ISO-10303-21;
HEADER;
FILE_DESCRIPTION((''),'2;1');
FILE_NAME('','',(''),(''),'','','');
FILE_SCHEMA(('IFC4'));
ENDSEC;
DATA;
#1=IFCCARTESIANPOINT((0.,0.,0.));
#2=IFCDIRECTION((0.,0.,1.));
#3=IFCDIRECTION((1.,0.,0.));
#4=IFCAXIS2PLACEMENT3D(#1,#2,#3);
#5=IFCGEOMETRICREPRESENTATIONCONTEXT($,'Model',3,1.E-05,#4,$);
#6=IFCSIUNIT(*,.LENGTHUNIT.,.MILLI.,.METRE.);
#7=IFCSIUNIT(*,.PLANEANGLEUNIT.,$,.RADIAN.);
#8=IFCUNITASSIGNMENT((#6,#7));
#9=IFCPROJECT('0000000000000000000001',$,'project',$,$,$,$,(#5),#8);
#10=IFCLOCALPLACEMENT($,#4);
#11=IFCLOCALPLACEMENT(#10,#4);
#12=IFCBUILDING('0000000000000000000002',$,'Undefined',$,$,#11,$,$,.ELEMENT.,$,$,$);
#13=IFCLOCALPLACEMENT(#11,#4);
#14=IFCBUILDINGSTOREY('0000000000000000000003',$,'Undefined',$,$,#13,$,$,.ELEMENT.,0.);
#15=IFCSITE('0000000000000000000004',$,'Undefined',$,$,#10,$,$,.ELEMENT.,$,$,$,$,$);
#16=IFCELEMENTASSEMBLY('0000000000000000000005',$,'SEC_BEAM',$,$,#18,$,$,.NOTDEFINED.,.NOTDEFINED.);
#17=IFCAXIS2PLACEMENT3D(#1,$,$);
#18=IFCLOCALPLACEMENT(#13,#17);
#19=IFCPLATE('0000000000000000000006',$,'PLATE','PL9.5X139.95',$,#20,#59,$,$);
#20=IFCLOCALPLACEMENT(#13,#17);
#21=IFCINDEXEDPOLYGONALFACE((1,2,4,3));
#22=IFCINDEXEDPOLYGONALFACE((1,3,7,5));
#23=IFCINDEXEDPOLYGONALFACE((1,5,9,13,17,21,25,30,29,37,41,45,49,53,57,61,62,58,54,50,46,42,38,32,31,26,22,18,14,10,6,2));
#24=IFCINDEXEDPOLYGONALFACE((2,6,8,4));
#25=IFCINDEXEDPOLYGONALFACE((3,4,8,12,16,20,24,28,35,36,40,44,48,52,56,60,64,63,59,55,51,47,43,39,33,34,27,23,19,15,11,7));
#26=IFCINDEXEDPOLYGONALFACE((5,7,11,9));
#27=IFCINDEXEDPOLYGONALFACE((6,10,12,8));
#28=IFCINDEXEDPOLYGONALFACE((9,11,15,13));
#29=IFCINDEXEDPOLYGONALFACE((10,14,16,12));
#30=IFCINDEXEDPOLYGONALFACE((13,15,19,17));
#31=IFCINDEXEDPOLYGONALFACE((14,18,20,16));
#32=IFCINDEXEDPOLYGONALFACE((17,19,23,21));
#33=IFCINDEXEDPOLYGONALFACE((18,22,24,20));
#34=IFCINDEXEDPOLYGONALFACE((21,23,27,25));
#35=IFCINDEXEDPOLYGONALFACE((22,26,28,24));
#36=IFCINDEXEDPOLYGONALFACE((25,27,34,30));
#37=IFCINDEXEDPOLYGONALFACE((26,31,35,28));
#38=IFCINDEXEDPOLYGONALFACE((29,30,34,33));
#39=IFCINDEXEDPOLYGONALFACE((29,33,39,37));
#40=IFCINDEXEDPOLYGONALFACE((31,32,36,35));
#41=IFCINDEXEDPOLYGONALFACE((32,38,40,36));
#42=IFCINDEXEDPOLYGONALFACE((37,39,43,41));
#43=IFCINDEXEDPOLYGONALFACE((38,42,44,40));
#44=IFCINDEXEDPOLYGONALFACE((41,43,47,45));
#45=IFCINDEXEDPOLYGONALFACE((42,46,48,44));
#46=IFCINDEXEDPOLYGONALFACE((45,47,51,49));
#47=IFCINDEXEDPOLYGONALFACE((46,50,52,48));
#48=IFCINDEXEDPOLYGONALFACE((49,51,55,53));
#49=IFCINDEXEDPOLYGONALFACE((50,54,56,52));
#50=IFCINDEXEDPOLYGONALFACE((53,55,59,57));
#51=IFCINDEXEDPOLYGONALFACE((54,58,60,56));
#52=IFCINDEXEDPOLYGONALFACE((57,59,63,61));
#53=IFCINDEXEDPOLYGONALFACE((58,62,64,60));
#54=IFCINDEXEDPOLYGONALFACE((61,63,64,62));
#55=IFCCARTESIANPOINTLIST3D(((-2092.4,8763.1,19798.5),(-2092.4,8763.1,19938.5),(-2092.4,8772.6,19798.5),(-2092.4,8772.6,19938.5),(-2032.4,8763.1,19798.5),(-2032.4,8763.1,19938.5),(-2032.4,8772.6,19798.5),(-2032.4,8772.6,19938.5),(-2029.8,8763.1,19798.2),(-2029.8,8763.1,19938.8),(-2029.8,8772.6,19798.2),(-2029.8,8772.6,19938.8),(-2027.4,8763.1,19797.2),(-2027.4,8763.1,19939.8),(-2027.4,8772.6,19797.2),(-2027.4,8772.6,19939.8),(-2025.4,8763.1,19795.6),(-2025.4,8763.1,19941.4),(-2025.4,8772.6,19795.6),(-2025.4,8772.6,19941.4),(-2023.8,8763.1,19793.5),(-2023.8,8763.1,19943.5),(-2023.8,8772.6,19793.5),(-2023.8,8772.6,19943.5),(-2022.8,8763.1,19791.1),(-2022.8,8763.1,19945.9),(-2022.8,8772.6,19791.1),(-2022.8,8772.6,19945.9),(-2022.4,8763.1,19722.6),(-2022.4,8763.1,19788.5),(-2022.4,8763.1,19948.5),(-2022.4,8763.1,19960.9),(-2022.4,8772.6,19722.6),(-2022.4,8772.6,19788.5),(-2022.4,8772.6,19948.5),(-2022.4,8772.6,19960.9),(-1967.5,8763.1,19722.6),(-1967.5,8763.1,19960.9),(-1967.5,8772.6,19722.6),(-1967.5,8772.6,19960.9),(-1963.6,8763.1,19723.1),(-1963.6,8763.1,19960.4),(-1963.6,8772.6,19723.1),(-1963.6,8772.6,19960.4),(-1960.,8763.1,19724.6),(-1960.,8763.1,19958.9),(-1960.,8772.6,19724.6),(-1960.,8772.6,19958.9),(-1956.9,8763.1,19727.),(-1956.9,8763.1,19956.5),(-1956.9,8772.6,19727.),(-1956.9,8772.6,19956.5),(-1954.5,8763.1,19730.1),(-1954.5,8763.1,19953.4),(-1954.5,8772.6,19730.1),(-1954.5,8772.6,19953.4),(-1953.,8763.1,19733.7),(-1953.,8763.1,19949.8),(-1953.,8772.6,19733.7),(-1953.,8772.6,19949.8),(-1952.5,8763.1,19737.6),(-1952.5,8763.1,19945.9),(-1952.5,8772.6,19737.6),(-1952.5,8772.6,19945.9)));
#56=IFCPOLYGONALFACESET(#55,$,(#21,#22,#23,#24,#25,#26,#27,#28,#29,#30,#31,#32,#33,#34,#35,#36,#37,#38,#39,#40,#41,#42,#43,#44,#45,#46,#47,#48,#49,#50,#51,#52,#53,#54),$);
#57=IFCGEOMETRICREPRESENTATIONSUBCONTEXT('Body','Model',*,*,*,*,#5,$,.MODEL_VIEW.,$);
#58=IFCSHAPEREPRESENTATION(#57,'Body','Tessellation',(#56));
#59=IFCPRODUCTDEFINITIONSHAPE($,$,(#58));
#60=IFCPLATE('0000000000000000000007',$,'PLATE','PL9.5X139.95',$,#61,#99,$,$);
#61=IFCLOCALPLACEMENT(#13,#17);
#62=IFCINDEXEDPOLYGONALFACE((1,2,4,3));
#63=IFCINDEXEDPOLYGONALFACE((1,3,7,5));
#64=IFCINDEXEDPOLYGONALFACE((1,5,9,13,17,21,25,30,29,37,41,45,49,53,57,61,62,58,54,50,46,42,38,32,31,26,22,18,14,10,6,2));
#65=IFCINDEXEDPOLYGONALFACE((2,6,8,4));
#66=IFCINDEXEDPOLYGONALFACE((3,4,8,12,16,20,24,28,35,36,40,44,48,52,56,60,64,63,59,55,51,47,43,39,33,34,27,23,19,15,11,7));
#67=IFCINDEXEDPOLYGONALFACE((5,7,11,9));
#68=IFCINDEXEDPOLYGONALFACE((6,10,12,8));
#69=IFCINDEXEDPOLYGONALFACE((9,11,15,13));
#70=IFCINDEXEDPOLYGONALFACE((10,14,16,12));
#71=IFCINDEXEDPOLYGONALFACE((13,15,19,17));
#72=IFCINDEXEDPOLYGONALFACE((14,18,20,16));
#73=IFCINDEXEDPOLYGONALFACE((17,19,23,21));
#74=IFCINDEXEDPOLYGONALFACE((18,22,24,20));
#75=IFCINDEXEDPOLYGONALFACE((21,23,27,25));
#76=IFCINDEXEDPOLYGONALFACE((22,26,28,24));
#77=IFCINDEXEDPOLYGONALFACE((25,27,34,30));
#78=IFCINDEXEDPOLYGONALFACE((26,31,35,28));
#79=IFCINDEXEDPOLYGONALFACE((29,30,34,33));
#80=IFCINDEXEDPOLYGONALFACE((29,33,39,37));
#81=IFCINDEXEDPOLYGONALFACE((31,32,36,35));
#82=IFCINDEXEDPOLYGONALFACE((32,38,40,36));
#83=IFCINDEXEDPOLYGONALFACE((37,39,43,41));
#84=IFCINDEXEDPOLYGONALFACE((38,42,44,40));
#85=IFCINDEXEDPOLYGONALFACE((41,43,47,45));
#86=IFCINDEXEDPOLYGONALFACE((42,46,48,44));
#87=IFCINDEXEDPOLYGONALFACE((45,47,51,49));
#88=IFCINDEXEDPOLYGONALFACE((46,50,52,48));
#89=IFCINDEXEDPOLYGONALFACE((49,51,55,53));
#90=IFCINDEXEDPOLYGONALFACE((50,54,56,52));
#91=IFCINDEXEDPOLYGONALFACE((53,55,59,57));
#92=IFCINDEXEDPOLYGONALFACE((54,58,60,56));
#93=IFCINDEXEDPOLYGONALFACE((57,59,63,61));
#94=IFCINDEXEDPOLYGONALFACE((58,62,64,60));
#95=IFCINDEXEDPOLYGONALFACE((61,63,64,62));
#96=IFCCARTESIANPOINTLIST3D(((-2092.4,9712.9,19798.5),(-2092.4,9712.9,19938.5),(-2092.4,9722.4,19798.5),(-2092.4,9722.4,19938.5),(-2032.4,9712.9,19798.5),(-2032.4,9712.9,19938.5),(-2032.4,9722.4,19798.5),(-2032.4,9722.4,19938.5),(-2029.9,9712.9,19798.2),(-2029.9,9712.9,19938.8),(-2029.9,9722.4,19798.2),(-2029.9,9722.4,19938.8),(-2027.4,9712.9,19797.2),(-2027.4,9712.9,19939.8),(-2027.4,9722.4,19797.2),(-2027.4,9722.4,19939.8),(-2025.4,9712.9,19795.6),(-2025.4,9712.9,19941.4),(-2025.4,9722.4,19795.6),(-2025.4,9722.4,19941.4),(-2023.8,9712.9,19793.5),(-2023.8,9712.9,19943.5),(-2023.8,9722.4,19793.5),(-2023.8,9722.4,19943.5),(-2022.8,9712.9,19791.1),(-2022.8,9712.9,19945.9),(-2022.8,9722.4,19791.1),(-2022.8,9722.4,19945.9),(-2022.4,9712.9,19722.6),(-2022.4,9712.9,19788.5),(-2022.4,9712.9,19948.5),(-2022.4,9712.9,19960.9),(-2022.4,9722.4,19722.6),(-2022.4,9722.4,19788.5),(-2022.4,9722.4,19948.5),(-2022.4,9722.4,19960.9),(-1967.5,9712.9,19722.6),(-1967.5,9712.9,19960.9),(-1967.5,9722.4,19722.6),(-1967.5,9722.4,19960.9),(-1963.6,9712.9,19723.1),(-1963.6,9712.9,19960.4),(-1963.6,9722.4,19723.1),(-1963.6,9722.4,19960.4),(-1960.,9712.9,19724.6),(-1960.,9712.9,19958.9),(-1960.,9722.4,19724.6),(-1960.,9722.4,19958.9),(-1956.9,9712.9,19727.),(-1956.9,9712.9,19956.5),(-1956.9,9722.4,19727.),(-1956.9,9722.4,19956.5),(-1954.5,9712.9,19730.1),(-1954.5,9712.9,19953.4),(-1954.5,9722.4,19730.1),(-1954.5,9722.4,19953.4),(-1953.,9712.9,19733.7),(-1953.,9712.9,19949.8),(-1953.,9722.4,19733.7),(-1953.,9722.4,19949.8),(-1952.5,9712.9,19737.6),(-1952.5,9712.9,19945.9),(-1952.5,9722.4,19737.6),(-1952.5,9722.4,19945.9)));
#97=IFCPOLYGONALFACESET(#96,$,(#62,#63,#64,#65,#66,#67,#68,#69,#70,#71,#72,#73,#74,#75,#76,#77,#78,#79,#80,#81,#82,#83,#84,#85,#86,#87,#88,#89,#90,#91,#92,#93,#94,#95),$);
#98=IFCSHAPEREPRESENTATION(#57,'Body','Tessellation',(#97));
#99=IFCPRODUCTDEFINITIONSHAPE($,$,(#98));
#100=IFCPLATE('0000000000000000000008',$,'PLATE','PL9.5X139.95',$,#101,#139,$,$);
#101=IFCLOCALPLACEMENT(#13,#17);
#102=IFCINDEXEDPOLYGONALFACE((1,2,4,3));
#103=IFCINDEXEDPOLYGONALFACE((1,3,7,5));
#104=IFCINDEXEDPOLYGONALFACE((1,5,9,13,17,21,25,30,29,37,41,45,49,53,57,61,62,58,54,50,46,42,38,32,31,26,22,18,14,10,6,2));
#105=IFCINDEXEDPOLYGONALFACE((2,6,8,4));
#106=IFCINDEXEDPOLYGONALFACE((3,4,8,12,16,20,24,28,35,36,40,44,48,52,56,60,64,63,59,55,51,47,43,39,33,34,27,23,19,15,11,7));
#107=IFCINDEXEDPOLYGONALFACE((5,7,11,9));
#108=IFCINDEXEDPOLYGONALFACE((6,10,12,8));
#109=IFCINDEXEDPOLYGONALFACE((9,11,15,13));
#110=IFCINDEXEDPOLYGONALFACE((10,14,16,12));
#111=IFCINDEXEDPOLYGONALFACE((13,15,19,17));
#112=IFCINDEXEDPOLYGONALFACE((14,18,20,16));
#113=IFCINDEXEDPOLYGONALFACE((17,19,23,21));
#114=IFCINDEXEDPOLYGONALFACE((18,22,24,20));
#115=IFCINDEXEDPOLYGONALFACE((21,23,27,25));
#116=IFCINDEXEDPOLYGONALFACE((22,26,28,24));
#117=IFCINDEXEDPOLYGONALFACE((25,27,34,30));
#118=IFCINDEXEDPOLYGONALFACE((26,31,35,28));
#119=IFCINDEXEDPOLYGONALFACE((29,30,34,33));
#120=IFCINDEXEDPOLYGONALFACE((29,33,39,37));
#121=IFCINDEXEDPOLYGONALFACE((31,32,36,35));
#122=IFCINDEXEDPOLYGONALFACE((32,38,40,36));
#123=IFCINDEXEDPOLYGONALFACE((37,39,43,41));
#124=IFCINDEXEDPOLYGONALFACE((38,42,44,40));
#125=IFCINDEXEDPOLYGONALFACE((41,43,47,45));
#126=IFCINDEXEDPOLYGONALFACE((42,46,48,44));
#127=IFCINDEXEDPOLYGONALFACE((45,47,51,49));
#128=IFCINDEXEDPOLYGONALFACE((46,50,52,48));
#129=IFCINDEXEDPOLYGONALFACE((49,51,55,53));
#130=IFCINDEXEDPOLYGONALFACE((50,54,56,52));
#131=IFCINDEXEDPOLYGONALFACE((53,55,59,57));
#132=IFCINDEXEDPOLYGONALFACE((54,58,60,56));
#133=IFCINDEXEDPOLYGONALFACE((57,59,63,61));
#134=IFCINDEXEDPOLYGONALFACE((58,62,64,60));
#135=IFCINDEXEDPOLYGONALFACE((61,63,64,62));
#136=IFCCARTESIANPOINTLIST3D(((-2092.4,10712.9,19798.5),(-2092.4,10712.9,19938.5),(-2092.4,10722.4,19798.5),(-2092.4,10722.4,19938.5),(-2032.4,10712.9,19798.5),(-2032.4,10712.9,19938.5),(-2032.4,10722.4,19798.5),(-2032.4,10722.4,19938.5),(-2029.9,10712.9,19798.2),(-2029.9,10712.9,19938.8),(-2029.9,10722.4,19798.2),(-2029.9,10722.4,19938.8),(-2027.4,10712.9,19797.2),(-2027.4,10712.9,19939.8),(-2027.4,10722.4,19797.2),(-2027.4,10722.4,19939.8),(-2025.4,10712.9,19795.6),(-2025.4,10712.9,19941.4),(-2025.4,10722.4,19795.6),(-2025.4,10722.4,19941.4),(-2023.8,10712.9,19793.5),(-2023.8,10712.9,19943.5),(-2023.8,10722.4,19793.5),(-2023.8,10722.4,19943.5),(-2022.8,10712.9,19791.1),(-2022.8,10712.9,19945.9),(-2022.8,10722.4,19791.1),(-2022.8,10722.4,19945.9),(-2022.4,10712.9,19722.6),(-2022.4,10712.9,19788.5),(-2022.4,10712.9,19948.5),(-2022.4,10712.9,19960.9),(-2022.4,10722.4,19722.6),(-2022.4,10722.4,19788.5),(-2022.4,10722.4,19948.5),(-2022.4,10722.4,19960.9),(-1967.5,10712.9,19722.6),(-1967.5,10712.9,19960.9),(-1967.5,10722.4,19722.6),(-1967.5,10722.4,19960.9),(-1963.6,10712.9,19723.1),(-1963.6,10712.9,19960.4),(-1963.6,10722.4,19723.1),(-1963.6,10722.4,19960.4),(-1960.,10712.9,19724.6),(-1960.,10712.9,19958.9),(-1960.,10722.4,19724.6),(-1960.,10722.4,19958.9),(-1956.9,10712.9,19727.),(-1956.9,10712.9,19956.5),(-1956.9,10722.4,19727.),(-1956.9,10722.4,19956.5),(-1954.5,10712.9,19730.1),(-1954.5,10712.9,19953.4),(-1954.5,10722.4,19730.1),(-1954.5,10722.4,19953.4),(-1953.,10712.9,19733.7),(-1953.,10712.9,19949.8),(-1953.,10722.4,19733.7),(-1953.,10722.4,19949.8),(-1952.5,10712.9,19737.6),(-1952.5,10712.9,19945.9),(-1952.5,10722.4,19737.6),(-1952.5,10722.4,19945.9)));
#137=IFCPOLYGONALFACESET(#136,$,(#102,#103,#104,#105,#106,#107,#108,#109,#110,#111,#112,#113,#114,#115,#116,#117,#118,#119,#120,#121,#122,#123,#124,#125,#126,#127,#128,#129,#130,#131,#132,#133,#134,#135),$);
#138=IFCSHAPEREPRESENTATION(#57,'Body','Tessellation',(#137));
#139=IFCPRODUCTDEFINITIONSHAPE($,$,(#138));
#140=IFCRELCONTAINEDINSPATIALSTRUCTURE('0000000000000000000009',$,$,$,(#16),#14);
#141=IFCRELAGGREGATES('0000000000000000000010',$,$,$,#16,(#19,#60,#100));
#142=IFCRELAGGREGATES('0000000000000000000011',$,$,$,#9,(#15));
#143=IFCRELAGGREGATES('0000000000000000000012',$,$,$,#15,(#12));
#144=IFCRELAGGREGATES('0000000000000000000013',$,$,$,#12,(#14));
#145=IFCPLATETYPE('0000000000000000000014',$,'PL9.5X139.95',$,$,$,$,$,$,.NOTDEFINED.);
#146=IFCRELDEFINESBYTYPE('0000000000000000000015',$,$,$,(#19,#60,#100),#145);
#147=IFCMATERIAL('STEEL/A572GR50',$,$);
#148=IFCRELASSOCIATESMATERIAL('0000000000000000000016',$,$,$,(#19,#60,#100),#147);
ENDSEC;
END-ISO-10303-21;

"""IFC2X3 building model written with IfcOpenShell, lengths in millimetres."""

from ifc_helpers import new_model, si_unit, frame, frame_2d, origin_with_axes, place, context, subcontext, project, spatial, polyline, circle_curve, parameter, trimmed, segment, composite_curve, outline, extrude, material, type_object, element, aggregate, save


model = new_model("IFC2X3")

# Units and contexts
model_context = context("Model", 3, precision=1e-05, world=origin_with_axes())
body_context = subcontext(model_context, "Body", "Model", "MODEL_VIEW")
ifc_project = project(units=[si_unit("LENGTHUNIT", "METRE", prefix="MILLI"), si_unit("PLANEANGLEUNIT", "RADIAN")], contexts=[model_context])

# Site, building, storey
site_placement = place(None, origin_with_axes())
site = spatial("IfcSite", under=ifc_project, at=site_placement, Name="Undefined", CompositionType="ELEMENT")
building_placement = place(site_placement, origin_with_axes())
building = spatial("IfcBuilding", under=site, at=building_placement, Name="Undefined", CompositionType="ELEMENT")
storey_placement = place(building_placement, origin_with_axes())
storey = spatial("IfcBuildingStorey", under=building, at=storey_placement, Name="Undefined", CompositionType="ELEMENT", Elevation=0.0)

# Element assembly
ifc_material_1 = material(Name="STEEL/A572GR50")
assembly_1_placement = place(storey_placement, origin_with_axes())
assembly_1 = element("IfcElementAssembly", 1, at=assembly_1_placement, inside=storey, Name="SEC_BEAM", AssemblyPlace="NOTDEFINED", PredefinedType="NOTDEFINED")

# Plates
plate_type_1 = type_object("IfcPlateType", Name="PL9.5X139.95", PredefinedType="NOTDEFINED")
plate_1_placement = place(assembly_1_placement, frame((-1952.5, 8767.8, 19960.9), z_axis=(0.000056, 1.0, 0.0), x_axis=(0.0, 0.0, -1.0)))
plate_1 = element("IfcPlate", 2, at=plate_1_placement, type_object=plate_type_1, material=ifc_material_1, Name="PLATE", Description="PL9.5X139.95", context=body_context, shape_type="SweptSolid", body=[
    extrude(outline(composite_curve([segment(trimmed(circle_curve(frame_2d((15.0, 15.0), x_axis=(-1.0, 0.0)), 15.0), [parameter(0.0)], [parameter(1.570796)], True, "PARAMETER"), True, "CONTINUOUS"), segment(polyline([(15.0, 0.0), (223.3, 0.0)]), True, "CONTINUOUS"), segment(trimmed(circle_curve(frame_2d((223.3, 15.0), x_axis=(0.0, -1.0)), 15.0), [parameter(0.0)], [parameter(1.570796)], True, "PARAMETER"), True, "CONTINUOUS"), segment(polyline([(238.3, 15.0), (238.3, 69.9), (172.4, 69.9)]), True, "CONTINUOUS"), segment(trimmed(circle_curve(frame_2d((172.4, 79.9), x_axis=(0.0, -1.0)), 10.0), [parameter(0.0)], [parameter(4.712389)], False, "PARAMETER"), True, "CONTINUOUS"), segment(polyline([(162.4, 79.9), (162.4, 139.9), (22.4, 139.9), (22.4, 79.9)]), True, "CONTINUOUS"), segment(trimmed(circle_curve(frame_2d((12.4, 79.9), x_axis=(1.0, 0.0)), 10.0), [parameter(0.0)], [parameter(4.712389)], False, "PARAMETER"), True, "CONTINUOUS"), segment(polyline([(12.4, 69.9), (0.0, 69.9), (0.0, 15.0)]), True, "CONTINUOUS")], self_intersect=True)), frame((0.0, 0.0, -4.8), z_axis=(0.0, 0.0, 1.0), x_axis=(1.0, 0.0, 0.0)), (0.0, 0.0, 1.0), 9.5),
])
plate_2_placement = place(assembly_1_placement, frame((-1952.5, 9717.7, 19960.9), z_axis=(0.0, 1.0, 0.0), x_axis=(0.0, 0.0, -1.0)))
plate_2 = element("IfcPlate", 3, at=plate_2_placement, type_object=plate_type_1, material=ifc_material_1, Name="PLATE", Description="PL9.5X139.95", context=body_context, shape_type="SweptSolid", body=[
    extrude(outline(composite_curve([segment(trimmed(circle_curve(frame_2d((15.0, 15.0), x_axis=(-1.0, 0.0)), 15.0), [parameter(0.0)], [parameter(1.570796)], True, "PARAMETER"), True, "CONTINUOUS"), segment(polyline([(15.0, 0.0), (223.3, 0.0)]), True, "CONTINUOUS"), segment(trimmed(circle_curve(frame_2d((223.3, 15.0), x_axis=(0.0, -1.0)), 15.0), [parameter(0.0)], [parameter(1.570796)], True, "PARAMETER"), True, "CONTINUOUS"), segment(polyline([(238.3, 15.0), (238.3, 69.9), (172.4, 69.9)]), True, "CONTINUOUS"), segment(trimmed(circle_curve(frame_2d((172.4, 79.9), x_axis=(0.0, -1.0)), 10.0), [parameter(0.0)], [parameter(4.712389)], False, "PARAMETER"), True, "CONTINUOUS"), segment(polyline([(162.4, 79.9), (162.4, 139.9), (22.4, 139.9), (22.4, 79.9)]), True, "CONTINUOUS"), segment(trimmed(circle_curve(frame_2d((12.4, 79.9), x_axis=(1.0, 0.0)), 10.0), [parameter(0.0)], [parameter(4.712389)], False, "PARAMETER"), True, "CONTINUOUS"), segment(polyline([(12.4, 69.9), (0.0, 69.9), (0.0, 15.0)]), True, "CONTINUOUS")], self_intersect=True)), frame((0.0, 0.0, -4.8), z_axis=(0.0, 0.0, 1.0), x_axis=(1.0, 0.0, 0.0)), (0.0, 0.0, 1.0), 9.5),
])
plate_3_placement = place(assembly_1_placement, frame((-1952.5, 10717.7, 19960.9), z_axis=(0.0, 1.0, 0.0), x_axis=(0.0, 0.0, -1.0)))
plate_3 = element("IfcPlate", 4, at=plate_3_placement, type_object=plate_type_1, material=ifc_material_1, Name="PLATE", Description="PL9.5X139.95", context=body_context, shape_type="SweptSolid", body=[
    extrude(outline(composite_curve([segment(trimmed(circle_curve(frame_2d((15.0, 15.0), x_axis=(-1.0, 0.0)), 15.0), [parameter(0.0)], [parameter(1.570796)], True, "PARAMETER"), True, "CONTINUOUS"), segment(polyline([(15.0, 0.0), (223.3, 0.0)]), True, "CONTINUOUS"), segment(trimmed(circle_curve(frame_2d((223.3, 15.0), x_axis=(0.0, -1.0)), 15.0), [parameter(0.0)], [parameter(1.570796)], True, "PARAMETER"), True, "CONTINUOUS"), segment(polyline([(238.3, 15.0), (238.3, 69.9), (172.4, 69.9)]), True, "CONTINUOUS"), segment(trimmed(circle_curve(frame_2d((172.4, 79.9), x_axis=(0.0, -1.0)), 10.0), [parameter(0.0)], [parameter(4.712389)], False, "PARAMETER"), True, "CONTINUOUS"), segment(polyline([(162.4, 79.9), (162.4, 139.9), (22.4, 139.9), (22.4, 79.9)]), True, "CONTINUOUS"), segment(trimmed(circle_curve(frame_2d((12.4, 79.9), x_axis=(1.0, 0.0)), 10.0), [parameter(0.0)], [parameter(4.712389)], False, "PARAMETER"), True, "CONTINUOUS"), segment(polyline([(12.4, 69.9), (0.0, 69.9), (0.0, 15.0)]), True, "CONTINUOUS")], self_intersect=True)), frame((0.0, 0.0, -4.8), z_axis=(0.0, 0.0, 1.0), x_axis=(1.0, 0.0, 0.0)), (0.0, 0.0, 1.0), 9.5),
])

aggregate(assembly_1, [plate_1, plate_2, plate_3])

save(model, "model.ifc")
